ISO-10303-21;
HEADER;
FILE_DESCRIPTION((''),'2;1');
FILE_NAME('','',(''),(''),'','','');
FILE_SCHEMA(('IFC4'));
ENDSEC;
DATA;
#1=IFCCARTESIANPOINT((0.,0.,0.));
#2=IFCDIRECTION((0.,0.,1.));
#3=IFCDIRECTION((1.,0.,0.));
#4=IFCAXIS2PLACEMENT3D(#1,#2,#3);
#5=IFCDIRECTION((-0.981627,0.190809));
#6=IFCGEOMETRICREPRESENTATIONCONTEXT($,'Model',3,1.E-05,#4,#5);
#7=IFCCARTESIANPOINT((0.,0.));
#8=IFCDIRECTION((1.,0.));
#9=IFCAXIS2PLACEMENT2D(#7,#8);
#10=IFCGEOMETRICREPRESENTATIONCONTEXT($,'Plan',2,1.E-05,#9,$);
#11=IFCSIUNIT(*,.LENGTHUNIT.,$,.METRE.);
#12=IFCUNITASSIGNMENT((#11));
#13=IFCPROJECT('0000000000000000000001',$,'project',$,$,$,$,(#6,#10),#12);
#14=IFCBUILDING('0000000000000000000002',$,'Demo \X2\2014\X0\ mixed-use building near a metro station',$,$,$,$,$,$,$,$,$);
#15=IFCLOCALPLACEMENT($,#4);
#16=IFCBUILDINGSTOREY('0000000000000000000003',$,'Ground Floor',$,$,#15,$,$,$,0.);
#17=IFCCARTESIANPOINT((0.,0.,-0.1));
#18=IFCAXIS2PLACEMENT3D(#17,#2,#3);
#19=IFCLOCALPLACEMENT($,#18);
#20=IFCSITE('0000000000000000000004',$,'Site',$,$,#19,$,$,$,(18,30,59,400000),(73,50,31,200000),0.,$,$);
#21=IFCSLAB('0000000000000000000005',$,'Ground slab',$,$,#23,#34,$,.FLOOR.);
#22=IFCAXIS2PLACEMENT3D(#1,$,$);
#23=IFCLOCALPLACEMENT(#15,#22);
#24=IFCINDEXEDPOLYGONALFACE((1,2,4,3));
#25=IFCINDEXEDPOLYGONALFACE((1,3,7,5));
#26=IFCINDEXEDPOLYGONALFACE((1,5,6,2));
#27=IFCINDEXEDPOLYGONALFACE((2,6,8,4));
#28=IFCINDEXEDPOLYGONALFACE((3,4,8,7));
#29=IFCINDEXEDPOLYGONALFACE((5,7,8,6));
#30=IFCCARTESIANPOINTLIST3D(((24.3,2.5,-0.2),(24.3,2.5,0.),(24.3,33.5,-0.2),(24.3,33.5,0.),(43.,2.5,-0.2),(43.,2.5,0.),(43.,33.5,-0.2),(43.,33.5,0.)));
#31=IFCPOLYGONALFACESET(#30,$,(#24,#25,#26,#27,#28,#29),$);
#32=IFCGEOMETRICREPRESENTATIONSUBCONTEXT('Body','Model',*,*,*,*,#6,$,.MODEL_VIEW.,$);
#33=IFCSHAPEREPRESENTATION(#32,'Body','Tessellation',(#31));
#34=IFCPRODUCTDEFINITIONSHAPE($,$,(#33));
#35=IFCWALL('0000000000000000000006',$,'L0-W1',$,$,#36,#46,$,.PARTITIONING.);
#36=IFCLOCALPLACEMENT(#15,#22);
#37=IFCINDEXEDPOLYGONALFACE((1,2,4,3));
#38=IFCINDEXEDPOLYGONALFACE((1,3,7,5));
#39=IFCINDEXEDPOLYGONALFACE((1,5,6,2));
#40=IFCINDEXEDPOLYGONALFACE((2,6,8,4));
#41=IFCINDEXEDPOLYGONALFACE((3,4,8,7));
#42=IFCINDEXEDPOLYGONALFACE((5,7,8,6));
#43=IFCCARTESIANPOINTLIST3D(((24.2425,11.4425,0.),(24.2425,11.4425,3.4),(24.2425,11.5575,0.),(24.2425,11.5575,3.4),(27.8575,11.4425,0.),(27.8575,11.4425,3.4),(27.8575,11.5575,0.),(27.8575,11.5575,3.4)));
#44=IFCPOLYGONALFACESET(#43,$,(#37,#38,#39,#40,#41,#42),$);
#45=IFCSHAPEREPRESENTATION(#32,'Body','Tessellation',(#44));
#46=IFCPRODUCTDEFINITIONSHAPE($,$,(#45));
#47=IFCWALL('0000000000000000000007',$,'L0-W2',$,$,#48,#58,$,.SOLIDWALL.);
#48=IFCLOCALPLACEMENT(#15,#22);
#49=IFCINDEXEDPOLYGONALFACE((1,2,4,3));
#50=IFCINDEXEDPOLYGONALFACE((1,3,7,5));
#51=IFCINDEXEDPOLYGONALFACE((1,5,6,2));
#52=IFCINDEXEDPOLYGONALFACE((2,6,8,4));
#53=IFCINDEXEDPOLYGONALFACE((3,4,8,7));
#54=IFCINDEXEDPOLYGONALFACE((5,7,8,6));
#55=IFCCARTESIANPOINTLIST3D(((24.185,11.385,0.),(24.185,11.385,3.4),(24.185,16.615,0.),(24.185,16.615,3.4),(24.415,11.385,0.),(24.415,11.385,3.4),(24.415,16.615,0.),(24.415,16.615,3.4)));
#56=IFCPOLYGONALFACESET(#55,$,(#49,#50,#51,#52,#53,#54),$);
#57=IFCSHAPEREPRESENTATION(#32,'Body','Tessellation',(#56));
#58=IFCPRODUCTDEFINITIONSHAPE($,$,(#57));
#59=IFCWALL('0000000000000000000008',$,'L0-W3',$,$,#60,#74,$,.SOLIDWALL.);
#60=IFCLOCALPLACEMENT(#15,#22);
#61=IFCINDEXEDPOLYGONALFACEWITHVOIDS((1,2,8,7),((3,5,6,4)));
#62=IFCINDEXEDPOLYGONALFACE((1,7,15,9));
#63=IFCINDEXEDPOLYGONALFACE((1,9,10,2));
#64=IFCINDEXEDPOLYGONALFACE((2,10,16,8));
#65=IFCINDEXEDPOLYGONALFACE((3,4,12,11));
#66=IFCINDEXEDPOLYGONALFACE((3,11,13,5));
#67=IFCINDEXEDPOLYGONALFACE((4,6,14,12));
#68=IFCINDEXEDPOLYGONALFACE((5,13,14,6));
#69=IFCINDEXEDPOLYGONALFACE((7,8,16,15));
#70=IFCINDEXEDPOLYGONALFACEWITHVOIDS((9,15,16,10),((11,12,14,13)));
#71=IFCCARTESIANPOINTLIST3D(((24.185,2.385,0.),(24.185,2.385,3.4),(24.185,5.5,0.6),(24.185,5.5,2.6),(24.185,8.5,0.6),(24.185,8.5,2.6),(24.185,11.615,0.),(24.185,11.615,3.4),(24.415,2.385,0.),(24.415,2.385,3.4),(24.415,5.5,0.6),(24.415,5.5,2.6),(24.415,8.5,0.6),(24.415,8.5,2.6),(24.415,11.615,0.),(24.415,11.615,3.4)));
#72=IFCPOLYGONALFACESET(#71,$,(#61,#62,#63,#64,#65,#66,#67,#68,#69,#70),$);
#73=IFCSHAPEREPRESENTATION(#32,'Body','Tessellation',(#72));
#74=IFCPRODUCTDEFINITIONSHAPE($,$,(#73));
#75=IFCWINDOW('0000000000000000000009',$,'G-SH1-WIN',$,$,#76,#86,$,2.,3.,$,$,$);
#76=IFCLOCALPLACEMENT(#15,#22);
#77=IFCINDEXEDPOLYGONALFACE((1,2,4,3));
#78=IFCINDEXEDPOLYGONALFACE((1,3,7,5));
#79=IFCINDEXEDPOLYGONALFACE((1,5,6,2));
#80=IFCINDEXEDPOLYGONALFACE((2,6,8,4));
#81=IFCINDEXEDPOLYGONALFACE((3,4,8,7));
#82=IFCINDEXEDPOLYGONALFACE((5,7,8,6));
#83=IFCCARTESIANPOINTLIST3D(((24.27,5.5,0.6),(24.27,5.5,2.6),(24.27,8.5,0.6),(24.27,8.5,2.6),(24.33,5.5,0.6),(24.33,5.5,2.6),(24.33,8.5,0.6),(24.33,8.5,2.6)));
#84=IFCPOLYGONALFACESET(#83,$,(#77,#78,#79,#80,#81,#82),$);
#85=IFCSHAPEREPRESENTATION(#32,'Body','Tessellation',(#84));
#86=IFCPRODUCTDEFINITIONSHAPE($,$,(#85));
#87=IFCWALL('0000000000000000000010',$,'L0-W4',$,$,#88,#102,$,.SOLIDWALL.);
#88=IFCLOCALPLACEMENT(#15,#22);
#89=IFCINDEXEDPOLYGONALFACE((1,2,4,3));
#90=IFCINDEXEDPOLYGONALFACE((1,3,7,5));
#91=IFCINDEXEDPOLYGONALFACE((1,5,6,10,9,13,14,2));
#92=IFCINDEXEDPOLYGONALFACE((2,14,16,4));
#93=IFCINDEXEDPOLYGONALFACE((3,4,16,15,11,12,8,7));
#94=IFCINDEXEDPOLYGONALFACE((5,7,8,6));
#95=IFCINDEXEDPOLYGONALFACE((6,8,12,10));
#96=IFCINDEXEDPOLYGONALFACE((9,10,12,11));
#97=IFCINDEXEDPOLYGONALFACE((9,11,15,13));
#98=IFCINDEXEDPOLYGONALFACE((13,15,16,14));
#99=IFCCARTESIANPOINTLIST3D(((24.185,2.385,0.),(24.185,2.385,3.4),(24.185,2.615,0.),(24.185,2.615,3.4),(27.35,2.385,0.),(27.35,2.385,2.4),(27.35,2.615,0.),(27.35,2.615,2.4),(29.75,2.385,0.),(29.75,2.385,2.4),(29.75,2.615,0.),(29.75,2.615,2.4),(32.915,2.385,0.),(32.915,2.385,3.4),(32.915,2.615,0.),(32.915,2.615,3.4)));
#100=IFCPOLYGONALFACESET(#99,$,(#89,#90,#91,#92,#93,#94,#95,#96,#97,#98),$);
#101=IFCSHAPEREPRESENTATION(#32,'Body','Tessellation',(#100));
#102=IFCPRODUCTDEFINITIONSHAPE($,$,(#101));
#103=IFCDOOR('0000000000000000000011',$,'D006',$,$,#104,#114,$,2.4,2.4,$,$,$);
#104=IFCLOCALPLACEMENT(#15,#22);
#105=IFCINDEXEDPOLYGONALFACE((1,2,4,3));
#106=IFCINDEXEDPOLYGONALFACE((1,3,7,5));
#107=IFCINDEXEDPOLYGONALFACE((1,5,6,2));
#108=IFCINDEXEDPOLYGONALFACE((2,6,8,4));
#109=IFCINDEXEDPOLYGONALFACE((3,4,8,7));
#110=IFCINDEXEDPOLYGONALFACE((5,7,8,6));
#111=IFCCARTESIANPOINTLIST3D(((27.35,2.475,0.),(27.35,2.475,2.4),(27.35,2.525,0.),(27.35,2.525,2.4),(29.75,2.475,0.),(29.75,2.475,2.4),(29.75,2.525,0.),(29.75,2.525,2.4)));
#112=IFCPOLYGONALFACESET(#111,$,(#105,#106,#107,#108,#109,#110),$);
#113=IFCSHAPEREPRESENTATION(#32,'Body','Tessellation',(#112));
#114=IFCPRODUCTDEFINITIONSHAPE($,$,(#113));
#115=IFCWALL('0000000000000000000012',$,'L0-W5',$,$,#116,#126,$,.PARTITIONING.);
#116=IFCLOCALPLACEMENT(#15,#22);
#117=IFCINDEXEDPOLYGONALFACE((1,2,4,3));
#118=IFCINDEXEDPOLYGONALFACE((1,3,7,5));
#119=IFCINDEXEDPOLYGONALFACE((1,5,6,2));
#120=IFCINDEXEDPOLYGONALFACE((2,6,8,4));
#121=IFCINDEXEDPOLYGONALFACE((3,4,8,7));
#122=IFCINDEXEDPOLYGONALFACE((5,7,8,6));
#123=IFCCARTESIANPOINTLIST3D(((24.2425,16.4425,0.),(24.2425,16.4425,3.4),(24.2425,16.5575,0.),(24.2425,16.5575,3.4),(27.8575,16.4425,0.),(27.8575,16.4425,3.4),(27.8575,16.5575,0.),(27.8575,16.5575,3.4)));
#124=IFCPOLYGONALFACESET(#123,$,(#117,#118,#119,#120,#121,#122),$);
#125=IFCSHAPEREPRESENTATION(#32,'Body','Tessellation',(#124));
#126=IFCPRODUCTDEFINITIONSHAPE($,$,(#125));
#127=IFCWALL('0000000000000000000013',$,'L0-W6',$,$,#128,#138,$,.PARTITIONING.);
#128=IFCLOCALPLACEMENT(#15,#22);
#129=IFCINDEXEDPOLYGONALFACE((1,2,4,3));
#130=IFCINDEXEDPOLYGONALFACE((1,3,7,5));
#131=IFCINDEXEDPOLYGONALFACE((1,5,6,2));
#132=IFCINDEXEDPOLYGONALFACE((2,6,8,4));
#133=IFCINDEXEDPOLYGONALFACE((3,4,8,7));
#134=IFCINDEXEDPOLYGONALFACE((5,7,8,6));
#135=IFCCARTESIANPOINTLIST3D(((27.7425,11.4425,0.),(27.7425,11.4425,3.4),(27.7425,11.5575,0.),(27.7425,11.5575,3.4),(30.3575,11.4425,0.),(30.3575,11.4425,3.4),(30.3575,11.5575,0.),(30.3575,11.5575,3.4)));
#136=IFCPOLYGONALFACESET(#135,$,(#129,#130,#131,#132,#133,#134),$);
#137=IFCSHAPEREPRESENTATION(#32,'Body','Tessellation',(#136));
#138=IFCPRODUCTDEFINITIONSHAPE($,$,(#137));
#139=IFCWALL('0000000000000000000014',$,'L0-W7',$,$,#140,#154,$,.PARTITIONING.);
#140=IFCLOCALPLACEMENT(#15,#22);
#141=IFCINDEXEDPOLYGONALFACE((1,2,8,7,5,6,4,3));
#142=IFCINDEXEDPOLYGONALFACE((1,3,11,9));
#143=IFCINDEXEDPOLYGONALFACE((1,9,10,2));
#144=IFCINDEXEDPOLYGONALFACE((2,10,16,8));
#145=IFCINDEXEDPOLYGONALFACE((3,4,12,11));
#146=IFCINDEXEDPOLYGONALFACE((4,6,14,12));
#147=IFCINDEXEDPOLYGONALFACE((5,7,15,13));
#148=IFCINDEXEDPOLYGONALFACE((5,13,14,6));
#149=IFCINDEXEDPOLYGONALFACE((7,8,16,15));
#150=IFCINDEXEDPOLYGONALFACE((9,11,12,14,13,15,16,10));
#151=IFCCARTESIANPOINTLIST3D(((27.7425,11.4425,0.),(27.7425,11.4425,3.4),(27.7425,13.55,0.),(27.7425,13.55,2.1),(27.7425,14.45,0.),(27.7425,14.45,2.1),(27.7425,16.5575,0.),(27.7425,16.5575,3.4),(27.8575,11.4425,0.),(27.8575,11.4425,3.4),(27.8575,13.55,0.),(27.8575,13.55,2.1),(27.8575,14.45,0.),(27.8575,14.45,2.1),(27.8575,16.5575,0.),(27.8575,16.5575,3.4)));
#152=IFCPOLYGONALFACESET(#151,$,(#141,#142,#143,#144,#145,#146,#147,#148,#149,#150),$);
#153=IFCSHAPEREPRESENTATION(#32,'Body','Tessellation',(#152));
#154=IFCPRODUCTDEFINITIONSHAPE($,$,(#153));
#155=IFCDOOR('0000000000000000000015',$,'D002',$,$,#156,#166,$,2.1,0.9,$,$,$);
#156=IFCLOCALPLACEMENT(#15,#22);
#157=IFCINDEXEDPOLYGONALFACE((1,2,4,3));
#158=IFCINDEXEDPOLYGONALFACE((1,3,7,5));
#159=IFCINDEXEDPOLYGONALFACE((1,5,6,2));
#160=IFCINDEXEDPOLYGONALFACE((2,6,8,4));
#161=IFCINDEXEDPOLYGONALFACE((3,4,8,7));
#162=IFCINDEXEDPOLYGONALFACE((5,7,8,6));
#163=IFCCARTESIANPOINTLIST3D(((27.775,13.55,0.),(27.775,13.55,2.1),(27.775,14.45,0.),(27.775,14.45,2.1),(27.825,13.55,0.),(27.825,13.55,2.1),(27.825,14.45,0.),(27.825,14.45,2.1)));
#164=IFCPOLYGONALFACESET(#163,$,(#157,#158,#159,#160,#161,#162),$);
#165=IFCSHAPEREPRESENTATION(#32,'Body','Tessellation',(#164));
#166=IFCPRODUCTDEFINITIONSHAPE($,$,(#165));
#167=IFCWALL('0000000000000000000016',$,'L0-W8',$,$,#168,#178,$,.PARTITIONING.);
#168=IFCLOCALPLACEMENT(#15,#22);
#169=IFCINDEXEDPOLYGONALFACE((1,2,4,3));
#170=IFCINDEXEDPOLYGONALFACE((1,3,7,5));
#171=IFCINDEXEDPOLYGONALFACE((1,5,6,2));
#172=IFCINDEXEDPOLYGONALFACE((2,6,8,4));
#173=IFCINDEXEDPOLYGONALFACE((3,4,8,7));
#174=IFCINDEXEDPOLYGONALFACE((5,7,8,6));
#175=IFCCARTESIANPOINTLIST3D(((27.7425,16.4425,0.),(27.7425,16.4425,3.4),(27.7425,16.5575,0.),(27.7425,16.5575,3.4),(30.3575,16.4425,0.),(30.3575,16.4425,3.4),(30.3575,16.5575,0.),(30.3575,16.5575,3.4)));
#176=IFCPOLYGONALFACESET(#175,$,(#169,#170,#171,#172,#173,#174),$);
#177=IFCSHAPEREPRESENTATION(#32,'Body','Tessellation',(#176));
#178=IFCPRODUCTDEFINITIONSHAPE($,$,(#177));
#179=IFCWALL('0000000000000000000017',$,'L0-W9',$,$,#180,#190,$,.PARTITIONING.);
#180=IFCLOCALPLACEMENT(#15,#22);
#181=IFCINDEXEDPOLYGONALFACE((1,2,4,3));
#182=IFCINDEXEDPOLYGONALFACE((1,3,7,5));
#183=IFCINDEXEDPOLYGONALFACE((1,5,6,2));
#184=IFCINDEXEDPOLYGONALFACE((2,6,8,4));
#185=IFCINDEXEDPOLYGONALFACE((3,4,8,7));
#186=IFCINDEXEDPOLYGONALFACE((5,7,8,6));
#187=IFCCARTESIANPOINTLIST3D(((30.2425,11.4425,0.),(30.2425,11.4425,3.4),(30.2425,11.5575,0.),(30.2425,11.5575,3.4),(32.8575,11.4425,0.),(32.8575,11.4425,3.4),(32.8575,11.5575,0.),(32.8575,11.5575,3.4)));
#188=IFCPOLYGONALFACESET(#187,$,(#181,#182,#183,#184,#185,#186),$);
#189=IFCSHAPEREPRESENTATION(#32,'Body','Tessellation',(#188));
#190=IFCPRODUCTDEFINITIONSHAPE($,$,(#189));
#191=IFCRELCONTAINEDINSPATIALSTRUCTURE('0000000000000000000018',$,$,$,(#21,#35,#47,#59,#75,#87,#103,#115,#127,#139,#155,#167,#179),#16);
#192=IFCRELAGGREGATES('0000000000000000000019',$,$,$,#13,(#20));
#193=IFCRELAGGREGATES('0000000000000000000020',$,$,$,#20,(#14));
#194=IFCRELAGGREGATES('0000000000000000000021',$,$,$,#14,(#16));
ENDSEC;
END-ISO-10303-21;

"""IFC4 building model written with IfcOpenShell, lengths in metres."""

from ifc_helpers import new_model, si_unit, direction, frame, origin_with_axes, origin_2d_with_axis, place, context, subcontext, project, spatial, line, indexed_curve, outline, extrude, element, fill, save


model = new_model("IFC4")

# Units and contexts
model_context = context("Model", 3, precision=1e-05, world=origin_with_axes(), true_north=direction((-0.981627, 0.190809)))
plan_context = context("Plan", 2, precision=1e-05, world=origin_2d_with_axis())
body_context = subcontext(model_context, "Body", "Model", "MODEL_VIEW")
ifc_project = project(units=[si_unit("LENGTHUNIT", "METRE")], contexts=[model_context, plan_context])

# Site, building, storey
site_placement = place(None, frame((0.0, 0.0, -0.1), z_axis=(0.0, 0.0, 1.0), x_axis=(1.0, 0.0, 0.0)))
site = spatial("IfcSite", under=ifc_project, at=site_placement, Name="Site", RefLatitude=(18, 30, 59, 400000), RefLongitude=(73, 50, 31, 200000), RefElevation=0.0)
building = spatial("IfcBuilding", under=site, Name="Demo — mixed-use building near a metro station")
storey_placement = place(None, origin_with_axes())
storey = spatial("IfcBuildingStorey", under=building, at=storey_placement, Name="Ground Floor", Elevation=0.0)

# Slab
slab_placement = place(storey_placement, frame((0.0, 0.0, -0.2), z_axis=(0.0, 0.0, 1.0), x_axis=(1.0, 0.0, 0.0)))
element("IfcSlab", 1, at=slab_placement, inside=storey, Name="Ground slab", PredefinedType="FLOOR", context=body_context, shape_type="SweptSolid", body=[
    extrude(outline(indexed_curve([(24.3, 2.5), (43.0, 2.5), (43.0, 33.5), (24.3, 33.5)], segments=[line(1, 2, 3, 4, 1)])), origin_with_axes(), (0.0, 0.0, 1.0), 0.2),
])

# Walls
wall_1_placement = place(storey_placement, origin_with_axes())
element("IfcWall", 2, at=wall_1_placement, inside=storey, Name="L0-W1", PredefinedType="PARTITIONING", context=body_context, shape_type="SweptSolid", body=[
    extrude(outline(indexed_curve([(27.8575, 11.4425), (24.2425, 11.4425), (24.2425, 11.5575), (27.8575, 11.5575)], segments=[line(1, 2, 3, 4, 1)])), origin_with_axes(), (0.0, 0.0, 1.0), 3.4),
])
wall_2_placement = place(storey_placement, origin_with_axes())
element("IfcWall", 3, at=wall_2_placement, inside=storey, Name="L0-W2", PredefinedType="SOLIDWALL", context=body_context, shape_type="SweptSolid", body=[
    extrude(outline(indexed_curve([(24.415, 16.615), (24.415, 11.385), (24.185, 11.385), (24.185, 16.615)], segments=[line(1, 2, 3, 4, 1)])), origin_with_axes(), (0.0, 0.0, 1.0), 3.4),
])

# Wall, opening, window
wall_3_placement = place(storey_placement, origin_with_axes())
wall_3 = element("IfcWall", 4, at=wall_3_placement, inside=storey, Name="L0-W3", PredefinedType="SOLIDWALL", context=body_context, shape_type="SweptSolid", body=[
    extrude(outline(indexed_curve([(24.415, 11.615), (24.415, 2.385), (24.185, 2.385), (24.185, 11.615)], segments=[line(1, 2, 3, 4, 1)])), origin_with_axes(), (0.0, 0.0, 1.0), 3.4),
])
opening_1_placement = place(wall_3_placement, origin_with_axes())
opening_1 = element("IfcOpeningElement", 5, at=opening_1_placement, cuts=wall_3, context=body_context, shape_type="SweptSolid", body=[
    extrude(outline(indexed_curve([(24.465, 8.5), (24.465, 5.5), (24.135, 5.5), (24.135, 8.5)], segments=[line(1, 2, 3, 4, 1)])), frame((0.0, 0.0, 0.6), z_axis=(0.0, 0.0, 1.0), x_axis=(1.0, 0.0, 0.0)), (0.0, 0.0, 1.0), 2.0),
])
window_placement = place(storey_placement, origin_with_axes())
window = element("IfcWindow", 6, at=window_placement, inside=storey, Name="G-SH1-WIN", OverallHeight=2.0, OverallWidth=3.0, context=body_context, shape_type="SweptSolid", body=[
    extrude(outline(indexed_curve([(24.33, 8.5), (24.33, 5.5), (24.27, 5.5), (24.27, 8.5)], segments=[line(1, 2, 3, 4, 1)])), frame((0.0, 0.0, 0.6), z_axis=(0.0, 0.0, 1.0), x_axis=(1.0, 0.0, 0.0)), (0.0, 0.0, 1.0), 2.0),
])
fill(opening_1, window)

# Wall, opening, door
wall_4_placement = place(storey_placement, origin_with_axes())
wall_4 = element("IfcWall", 7, at=wall_4_placement, inside=storey, Name="L0-W4", PredefinedType="SOLIDWALL", context=body_context, shape_type="SweptSolid", body=[
    extrude(outline(indexed_curve([(24.185, 2.615), (32.915, 2.615), (32.915, 2.385), (24.185, 2.385)], segments=[line(1, 2, 3, 4, 1)])), origin_with_axes(), (0.0, 0.0, 1.0), 3.4),
])
opening_2_placement = place(wall_4_placement, origin_with_axes())
opening_2 = element("IfcOpeningElement", 8, at=opening_2_placement, cuts=wall_4, context=body_context, shape_type="SweptSolid", body=[
    extrude(outline(indexed_curve([(27.35, 2.665), (29.75, 2.665), (29.75, 2.335), (27.35, 2.335)], segments=[line(1, 2, 3, 4, 1)])), origin_with_axes(), (0.0, 0.0, 1.0), 2.4),
])
door_1_placement = place(storey_placement, origin_with_axes())
door_1 = element("IfcDoor", 9, at=door_1_placement, inside=storey, Name="D006", OverallHeight=2.4, OverallWidth=2.4, context=body_context, shape_type="SweptSolid", body=[
    extrude(outline(indexed_curve([(27.35, 2.525), (29.75, 2.525), (29.75, 2.475), (27.35, 2.475)], segments=[line(1, 2, 3, 4, 1)])), origin_with_axes(), (0.0, 0.0, 1.0), 2.4),
])
fill(opening_2, door_1)

# Walls
wall_5_placement = place(storey_placement, origin_with_axes())
element("IfcWall", 10, at=wall_5_placement, inside=storey, Name="L0-W5", PredefinedType="PARTITIONING", context=body_context, shape_type="SweptSolid", body=[
    extrude(outline(indexed_curve([(27.8575, 16.4425), (24.2425, 16.4425), (24.2425, 16.5575), (27.8575, 16.5575)], segments=[line(1, 2, 3, 4, 1)])), origin_with_axes(), (0.0, 0.0, 1.0), 3.4),
])
wall_6_placement = place(storey_placement, origin_with_axes())
element("IfcWall", 11, at=wall_6_placement, inside=storey, Name="L0-W6", PredefinedType="PARTITIONING", context=body_context, shape_type="SweptSolid", body=[
    extrude(outline(indexed_curve([(30.3575, 11.4425), (27.7425, 11.4425), (27.7425, 11.5575), (30.3575, 11.5575)], segments=[line(1, 2, 3, 4, 1)])), origin_with_axes(), (0.0, 0.0, 1.0), 3.4),
])

# Wall, opening, door
wall_7_placement = place(storey_placement, origin_with_axes())
wall_7 = element("IfcWall", 12, at=wall_7_placement, inside=storey, Name="L0-W7", PredefinedType="PARTITIONING", context=body_context, shape_type="SweptSolid", body=[
    extrude(outline(indexed_curve([(27.7425, 11.4425), (27.7425, 16.5575), (27.8575, 16.5575), (27.8575, 11.4425)], segments=[line(1, 2, 3, 4, 1)])), origin_with_axes(), (0.0, 0.0, 1.0), 3.4),
])
opening_3_placement = place(wall_7_placement, origin_with_axes())
opening_3 = element("IfcOpeningElement", 13, at=opening_3_placement, cuts=wall_7, context=body_context, shape_type="SweptSolid", body=[
    extrude(outline(indexed_curve([(27.6925, 13.55), (27.6925, 14.45), (27.9075, 14.45), (27.9075, 13.55)], segments=[line(1, 2, 3, 4, 1)])), origin_with_axes(), (0.0, 0.0, 1.0), 2.1),
])
door_2_placement = place(storey_placement, origin_with_axes())
door_2 = element("IfcDoor", 14, at=door_2_placement, inside=storey, Name="D002", OverallHeight=2.1, OverallWidth=0.9, context=body_context, shape_type="SweptSolid", body=[
    extrude(outline(indexed_curve([(27.775, 13.55), (27.775, 14.45), (27.825, 14.45), (27.825, 13.55)], segments=[line(1, 2, 3, 4, 1)])), origin_with_axes(), (0.0, 0.0, 1.0), 2.1),
])
fill(opening_3, door_2)

# Walls
wall_8_placement = place(storey_placement, origin_with_axes())
element("IfcWall", 15, at=wall_8_placement, inside=storey, Name="L0-W8", PredefinedType="PARTITIONING", context=body_context, shape_type="SweptSolid", body=[
    extrude(outline(indexed_curve([(30.3575, 16.4425), (27.7425, 16.4425), (27.7425, 16.5575), (30.3575, 16.5575)], segments=[line(1, 2, 3, 4, 1)])), origin_with_axes(), (0.0, 0.0, 1.0), 3.4),
])
wall_9_placement = place(storey_placement, origin_with_axes())
element("IfcWall", 16, at=wall_9_placement, inside=storey, Name="L0-W9", PredefinedType="PARTITIONING", context=body_context, shape_type="SweptSolid", body=[
    extrude(outline(indexed_curve([(32.8575, 11.4425), (30.2425, 11.4425), (30.2425, 11.5575), (32.8575, 11.5575)], segments=[line(1, 2, 3, 4, 1)])), origin_with_axes(), (0.0, 0.0, 1.0), 3.4),
])

save(model, "model.ifc")
